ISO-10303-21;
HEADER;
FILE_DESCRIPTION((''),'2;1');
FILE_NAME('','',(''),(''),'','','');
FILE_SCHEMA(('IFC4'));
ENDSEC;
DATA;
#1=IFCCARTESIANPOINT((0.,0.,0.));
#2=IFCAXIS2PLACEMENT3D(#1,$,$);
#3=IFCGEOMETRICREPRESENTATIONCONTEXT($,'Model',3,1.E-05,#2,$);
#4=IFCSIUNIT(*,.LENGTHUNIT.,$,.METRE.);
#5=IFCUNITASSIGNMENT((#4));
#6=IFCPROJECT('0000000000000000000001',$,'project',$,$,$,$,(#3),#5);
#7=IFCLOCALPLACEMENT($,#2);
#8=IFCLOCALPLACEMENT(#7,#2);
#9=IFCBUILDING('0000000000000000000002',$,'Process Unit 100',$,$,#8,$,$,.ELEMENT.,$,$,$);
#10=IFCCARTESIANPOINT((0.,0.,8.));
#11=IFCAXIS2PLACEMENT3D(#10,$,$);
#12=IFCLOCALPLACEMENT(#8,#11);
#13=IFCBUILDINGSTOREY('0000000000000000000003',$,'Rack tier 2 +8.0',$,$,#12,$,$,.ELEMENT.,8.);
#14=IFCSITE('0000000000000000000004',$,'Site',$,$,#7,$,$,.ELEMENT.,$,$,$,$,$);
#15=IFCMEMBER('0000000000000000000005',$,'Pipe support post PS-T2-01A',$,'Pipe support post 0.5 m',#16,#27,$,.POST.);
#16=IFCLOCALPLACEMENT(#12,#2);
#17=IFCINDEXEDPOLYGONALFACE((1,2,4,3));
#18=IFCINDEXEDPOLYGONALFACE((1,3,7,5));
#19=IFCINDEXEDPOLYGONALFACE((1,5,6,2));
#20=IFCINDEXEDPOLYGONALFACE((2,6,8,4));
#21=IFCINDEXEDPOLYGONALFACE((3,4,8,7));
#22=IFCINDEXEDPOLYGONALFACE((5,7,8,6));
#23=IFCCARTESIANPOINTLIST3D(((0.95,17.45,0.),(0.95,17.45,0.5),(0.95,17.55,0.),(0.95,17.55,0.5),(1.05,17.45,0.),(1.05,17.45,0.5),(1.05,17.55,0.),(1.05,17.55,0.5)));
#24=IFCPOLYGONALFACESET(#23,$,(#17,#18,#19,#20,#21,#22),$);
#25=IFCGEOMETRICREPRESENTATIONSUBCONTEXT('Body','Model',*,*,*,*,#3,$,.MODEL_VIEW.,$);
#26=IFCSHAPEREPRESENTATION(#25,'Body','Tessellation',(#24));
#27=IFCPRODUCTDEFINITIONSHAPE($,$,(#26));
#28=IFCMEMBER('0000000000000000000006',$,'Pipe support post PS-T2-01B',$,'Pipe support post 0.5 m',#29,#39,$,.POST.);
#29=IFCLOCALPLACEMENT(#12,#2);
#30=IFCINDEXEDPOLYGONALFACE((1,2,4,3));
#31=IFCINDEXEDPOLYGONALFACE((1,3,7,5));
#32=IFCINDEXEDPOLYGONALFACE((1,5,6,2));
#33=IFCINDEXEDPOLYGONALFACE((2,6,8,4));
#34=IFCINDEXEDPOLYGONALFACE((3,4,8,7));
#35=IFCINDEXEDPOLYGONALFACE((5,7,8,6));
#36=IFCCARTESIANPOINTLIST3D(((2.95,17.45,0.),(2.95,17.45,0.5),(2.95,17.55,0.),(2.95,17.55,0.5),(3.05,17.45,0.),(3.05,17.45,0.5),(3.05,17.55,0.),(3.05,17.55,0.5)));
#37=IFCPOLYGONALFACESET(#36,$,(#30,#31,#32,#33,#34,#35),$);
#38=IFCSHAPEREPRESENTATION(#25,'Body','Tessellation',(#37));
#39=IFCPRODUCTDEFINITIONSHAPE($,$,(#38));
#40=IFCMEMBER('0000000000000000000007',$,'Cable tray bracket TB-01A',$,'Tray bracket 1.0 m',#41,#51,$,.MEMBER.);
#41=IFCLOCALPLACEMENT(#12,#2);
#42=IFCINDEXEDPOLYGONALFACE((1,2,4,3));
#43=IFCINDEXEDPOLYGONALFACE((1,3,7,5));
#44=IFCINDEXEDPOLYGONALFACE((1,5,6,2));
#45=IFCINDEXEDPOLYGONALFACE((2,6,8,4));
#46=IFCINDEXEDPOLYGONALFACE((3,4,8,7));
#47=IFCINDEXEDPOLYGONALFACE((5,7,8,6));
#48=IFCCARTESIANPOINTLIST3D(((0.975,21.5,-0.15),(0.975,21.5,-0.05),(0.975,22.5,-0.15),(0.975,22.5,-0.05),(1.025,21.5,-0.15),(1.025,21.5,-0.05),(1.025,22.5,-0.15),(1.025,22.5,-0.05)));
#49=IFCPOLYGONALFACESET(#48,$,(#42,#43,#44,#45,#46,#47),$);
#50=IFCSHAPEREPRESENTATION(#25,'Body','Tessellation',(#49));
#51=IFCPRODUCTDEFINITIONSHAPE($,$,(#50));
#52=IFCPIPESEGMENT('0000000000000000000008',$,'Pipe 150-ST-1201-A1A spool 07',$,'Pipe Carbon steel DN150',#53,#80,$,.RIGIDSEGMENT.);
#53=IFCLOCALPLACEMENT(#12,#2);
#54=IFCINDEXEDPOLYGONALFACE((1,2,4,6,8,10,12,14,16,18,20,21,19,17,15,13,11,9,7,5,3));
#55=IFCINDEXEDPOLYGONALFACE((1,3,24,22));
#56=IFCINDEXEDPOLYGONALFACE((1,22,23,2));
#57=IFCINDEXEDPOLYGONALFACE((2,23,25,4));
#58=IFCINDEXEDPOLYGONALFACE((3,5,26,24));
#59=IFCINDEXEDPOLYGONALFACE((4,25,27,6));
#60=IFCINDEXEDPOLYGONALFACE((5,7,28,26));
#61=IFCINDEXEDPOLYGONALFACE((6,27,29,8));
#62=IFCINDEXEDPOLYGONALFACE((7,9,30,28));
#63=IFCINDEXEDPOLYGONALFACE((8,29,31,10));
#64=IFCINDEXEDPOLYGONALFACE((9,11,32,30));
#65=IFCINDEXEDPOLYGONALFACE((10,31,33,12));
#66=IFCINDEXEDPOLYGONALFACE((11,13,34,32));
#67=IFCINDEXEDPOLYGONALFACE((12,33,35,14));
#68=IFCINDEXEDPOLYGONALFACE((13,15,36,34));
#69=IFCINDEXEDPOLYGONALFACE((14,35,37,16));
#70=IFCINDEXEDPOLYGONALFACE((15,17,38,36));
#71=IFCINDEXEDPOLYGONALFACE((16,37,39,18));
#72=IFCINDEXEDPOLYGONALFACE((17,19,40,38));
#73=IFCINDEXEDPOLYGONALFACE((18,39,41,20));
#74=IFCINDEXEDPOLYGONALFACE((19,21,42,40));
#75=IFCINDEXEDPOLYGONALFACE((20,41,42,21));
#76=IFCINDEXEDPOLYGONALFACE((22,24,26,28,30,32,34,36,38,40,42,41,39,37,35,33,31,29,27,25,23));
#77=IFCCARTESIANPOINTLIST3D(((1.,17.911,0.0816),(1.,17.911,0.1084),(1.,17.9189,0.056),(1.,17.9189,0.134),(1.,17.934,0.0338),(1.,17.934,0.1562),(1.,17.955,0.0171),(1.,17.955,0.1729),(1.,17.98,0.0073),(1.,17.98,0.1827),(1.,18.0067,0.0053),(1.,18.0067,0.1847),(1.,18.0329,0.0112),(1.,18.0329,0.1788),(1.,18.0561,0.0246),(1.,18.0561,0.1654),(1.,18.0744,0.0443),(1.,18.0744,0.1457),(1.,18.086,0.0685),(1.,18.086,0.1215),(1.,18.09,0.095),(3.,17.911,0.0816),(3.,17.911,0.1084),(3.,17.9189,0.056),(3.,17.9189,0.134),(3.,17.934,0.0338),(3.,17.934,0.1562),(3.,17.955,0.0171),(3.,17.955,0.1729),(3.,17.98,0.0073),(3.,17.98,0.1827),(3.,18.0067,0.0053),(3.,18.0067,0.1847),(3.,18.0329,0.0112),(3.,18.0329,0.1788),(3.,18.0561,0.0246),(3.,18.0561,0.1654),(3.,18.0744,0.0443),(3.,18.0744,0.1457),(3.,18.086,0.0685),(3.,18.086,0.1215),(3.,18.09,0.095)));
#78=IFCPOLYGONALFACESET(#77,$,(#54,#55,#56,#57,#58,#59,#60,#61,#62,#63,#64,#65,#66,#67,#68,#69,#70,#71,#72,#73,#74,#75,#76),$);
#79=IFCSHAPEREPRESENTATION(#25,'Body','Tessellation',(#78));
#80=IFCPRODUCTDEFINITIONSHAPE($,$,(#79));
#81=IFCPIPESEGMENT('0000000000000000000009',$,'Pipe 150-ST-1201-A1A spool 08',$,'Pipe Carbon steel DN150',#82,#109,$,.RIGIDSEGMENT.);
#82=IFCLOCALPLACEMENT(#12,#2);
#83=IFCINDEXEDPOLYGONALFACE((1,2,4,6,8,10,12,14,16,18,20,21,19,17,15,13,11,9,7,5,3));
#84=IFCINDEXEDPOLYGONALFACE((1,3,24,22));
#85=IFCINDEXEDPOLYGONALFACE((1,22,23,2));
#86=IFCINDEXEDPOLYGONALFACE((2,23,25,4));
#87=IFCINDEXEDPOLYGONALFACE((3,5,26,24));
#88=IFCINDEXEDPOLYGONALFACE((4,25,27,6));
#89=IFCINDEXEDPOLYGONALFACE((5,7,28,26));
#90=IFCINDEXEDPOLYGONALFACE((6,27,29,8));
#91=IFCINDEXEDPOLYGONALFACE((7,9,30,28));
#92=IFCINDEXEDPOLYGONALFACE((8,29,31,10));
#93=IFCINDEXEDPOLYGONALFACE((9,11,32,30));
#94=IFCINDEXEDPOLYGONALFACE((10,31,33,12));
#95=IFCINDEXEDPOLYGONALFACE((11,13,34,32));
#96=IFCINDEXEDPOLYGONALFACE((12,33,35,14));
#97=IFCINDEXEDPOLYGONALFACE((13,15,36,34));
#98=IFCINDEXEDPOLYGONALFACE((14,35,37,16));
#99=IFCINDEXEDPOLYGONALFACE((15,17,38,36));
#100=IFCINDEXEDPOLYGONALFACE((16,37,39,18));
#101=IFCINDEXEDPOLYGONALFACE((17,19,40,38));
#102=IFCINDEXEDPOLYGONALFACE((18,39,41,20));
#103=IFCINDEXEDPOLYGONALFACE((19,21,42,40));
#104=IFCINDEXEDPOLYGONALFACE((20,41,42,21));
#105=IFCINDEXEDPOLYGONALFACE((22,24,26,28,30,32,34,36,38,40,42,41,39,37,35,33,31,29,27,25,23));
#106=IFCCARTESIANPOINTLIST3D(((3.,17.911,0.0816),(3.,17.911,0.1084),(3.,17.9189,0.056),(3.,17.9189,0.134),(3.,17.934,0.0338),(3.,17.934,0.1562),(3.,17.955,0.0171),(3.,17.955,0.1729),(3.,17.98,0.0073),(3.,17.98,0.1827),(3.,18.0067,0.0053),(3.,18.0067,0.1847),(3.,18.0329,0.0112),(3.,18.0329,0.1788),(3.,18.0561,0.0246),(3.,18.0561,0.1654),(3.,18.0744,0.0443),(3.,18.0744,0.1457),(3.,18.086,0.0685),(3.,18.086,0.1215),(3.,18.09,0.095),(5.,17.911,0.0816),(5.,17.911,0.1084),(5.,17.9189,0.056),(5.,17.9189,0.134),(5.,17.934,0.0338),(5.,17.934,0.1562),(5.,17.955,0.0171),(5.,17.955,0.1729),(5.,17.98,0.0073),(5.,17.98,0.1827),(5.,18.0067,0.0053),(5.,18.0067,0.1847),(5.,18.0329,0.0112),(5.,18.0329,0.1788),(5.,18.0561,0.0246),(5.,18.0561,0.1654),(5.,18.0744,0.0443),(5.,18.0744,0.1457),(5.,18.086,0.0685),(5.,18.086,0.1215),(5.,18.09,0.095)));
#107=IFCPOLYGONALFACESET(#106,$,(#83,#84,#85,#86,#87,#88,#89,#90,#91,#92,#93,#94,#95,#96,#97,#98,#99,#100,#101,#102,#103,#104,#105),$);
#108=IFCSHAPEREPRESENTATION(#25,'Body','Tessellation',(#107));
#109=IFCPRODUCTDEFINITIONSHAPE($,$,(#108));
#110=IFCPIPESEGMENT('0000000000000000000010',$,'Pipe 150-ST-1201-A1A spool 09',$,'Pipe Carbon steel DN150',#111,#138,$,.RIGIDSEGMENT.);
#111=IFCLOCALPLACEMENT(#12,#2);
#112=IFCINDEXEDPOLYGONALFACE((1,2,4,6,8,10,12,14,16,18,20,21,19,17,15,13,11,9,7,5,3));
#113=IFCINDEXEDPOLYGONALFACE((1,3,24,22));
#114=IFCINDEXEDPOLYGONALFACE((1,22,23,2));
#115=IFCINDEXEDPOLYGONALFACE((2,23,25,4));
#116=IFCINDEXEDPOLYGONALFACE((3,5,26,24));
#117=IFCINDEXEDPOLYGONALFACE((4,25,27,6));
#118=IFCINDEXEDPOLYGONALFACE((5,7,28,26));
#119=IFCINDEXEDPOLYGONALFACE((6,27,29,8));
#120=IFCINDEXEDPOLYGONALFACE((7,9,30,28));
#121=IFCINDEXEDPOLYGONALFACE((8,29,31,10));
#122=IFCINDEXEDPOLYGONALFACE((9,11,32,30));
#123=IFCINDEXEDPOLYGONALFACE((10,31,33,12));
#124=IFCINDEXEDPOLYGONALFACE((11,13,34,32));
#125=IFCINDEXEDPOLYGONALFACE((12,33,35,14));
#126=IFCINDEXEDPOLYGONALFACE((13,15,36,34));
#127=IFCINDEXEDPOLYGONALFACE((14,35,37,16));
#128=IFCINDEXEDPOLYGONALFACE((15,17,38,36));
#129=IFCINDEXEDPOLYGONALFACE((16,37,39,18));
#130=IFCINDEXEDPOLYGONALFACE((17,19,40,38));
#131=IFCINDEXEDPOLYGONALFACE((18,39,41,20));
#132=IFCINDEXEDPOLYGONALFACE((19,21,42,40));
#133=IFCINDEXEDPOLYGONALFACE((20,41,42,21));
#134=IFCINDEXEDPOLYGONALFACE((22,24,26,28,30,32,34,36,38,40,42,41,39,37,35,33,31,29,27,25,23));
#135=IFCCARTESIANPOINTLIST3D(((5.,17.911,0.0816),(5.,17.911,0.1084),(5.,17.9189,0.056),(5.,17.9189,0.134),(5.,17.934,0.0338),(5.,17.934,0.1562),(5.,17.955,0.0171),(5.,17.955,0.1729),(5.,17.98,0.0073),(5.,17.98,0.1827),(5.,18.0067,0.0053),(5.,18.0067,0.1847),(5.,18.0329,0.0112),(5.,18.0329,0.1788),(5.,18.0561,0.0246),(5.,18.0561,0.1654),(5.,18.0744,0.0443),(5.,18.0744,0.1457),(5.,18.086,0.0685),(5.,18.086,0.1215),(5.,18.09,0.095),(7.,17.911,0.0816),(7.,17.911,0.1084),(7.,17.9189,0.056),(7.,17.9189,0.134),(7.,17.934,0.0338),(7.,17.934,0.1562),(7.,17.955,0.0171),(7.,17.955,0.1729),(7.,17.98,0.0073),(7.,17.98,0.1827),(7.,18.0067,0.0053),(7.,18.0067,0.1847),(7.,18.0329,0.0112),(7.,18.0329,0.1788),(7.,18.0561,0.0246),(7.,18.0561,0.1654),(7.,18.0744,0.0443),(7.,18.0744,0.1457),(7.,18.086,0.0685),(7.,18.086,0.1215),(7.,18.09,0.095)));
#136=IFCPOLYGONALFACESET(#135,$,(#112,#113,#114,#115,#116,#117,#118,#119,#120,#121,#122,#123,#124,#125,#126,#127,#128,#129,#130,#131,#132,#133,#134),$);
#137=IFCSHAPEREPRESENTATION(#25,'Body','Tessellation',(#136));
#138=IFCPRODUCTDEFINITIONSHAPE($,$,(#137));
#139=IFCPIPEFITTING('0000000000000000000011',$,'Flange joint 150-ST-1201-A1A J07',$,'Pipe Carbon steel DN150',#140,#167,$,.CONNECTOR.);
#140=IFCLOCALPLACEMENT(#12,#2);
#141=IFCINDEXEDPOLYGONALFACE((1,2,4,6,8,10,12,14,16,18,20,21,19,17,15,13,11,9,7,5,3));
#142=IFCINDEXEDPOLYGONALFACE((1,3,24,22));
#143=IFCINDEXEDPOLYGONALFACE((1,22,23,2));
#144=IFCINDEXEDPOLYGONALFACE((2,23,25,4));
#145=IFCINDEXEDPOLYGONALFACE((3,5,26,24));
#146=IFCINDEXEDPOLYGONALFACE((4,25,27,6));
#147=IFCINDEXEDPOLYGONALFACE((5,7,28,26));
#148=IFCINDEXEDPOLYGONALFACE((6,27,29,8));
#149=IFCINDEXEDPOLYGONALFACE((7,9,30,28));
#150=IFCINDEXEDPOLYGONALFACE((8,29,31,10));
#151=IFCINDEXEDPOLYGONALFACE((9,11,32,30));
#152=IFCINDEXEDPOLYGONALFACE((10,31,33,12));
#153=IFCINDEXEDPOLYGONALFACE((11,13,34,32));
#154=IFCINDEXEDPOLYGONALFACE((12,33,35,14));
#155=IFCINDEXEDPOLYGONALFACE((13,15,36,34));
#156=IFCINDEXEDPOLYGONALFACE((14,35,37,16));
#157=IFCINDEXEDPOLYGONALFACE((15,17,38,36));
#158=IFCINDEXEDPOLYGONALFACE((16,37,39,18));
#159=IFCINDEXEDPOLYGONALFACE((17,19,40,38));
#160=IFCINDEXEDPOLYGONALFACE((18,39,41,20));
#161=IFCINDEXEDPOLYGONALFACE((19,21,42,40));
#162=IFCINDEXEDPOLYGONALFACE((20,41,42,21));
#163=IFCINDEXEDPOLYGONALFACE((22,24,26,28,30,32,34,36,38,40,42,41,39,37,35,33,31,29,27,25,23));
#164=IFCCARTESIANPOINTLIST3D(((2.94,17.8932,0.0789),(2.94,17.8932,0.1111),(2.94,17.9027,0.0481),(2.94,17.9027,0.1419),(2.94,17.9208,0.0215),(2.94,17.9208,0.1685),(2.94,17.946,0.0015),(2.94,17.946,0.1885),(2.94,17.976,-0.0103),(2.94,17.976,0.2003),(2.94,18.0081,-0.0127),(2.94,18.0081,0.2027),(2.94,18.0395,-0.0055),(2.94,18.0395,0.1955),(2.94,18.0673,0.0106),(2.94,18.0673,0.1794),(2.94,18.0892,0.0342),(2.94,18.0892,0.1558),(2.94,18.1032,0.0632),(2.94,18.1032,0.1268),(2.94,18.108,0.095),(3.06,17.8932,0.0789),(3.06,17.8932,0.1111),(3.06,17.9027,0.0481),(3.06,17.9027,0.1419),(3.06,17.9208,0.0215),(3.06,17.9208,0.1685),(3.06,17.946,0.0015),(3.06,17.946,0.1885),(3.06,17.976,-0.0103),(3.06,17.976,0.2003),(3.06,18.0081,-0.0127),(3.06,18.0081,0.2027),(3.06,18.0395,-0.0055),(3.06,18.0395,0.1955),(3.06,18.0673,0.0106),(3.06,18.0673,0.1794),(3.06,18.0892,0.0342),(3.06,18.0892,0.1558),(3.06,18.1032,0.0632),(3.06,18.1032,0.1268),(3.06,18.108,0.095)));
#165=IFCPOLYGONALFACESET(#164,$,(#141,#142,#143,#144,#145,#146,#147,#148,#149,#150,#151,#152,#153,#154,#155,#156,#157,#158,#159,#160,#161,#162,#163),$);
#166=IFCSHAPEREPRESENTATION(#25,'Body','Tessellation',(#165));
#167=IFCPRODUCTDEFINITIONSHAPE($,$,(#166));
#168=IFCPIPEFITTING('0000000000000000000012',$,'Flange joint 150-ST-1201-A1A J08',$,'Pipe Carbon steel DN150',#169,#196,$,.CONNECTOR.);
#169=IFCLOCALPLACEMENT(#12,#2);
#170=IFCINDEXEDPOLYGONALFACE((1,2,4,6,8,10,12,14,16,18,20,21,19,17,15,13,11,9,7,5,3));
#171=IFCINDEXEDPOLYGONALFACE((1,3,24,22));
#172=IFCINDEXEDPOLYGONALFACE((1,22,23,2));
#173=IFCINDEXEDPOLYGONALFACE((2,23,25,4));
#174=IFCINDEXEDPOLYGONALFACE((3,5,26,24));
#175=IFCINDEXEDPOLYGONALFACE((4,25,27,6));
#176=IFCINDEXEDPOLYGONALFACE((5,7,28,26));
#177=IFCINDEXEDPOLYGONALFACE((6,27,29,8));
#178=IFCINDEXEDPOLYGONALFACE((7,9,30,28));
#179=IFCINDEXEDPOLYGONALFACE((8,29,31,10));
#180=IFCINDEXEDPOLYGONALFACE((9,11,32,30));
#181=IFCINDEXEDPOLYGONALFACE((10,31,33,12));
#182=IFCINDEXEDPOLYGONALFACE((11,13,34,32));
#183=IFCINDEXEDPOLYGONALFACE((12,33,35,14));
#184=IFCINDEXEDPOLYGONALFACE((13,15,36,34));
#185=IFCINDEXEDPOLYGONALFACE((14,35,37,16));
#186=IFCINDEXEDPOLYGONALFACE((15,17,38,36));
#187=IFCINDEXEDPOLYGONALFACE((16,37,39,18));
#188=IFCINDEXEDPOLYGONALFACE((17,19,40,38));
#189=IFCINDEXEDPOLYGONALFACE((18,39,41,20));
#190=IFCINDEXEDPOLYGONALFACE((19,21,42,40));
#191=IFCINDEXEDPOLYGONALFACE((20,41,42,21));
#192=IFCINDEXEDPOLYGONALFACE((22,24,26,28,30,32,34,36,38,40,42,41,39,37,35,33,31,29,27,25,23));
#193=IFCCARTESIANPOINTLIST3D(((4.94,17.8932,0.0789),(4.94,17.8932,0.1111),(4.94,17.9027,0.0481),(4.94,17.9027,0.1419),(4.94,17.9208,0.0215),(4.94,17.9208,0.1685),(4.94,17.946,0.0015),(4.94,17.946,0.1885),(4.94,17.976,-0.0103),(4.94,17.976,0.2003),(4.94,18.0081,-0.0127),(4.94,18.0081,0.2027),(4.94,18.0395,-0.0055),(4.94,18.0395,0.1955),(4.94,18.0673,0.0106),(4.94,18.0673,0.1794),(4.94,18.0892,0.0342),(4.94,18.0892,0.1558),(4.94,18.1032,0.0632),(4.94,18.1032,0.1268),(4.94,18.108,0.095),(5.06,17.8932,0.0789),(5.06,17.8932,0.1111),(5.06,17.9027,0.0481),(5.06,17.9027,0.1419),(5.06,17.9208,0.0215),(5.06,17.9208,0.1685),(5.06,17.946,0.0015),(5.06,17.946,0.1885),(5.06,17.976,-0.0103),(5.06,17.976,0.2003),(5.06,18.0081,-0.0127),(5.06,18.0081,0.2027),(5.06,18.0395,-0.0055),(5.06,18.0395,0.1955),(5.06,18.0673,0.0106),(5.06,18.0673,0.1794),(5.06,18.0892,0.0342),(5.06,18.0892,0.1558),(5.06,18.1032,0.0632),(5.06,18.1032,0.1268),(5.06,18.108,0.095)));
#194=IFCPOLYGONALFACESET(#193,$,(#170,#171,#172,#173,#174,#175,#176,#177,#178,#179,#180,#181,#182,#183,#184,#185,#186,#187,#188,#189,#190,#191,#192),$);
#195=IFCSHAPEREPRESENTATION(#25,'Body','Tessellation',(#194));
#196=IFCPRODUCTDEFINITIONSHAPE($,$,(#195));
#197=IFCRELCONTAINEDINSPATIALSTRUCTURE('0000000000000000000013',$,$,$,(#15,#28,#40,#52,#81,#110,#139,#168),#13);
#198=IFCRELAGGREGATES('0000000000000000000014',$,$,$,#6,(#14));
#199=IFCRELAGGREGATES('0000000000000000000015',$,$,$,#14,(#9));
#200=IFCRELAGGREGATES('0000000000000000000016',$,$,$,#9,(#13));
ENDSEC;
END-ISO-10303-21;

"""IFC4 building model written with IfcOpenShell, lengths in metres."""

from ifc_helpers import new_model, si_unit, frame, origin, place, context, subcontext, project, spatial, rectangle, circle, extrude, element, save


model = new_model("IFC4")

# Units and contexts
model_context = context("Model", 3, precision=1e-05, world=origin())
body_context = subcontext(model_context, "Body", "Model", "MODEL_VIEW")
ifc_project = project(units=[si_unit("LENGTHUNIT", "METRE")], contexts=[model_context])

# Site, building, storey
site_placement = place(None, origin())
site = spatial("IfcSite", under=ifc_project, at=site_placement, Name="Site", CompositionType="ELEMENT")
building_placement = place(site_placement, origin())
building = spatial("IfcBuilding", under=site, at=building_placement, Name="Process Unit 100", CompositionType="ELEMENT")
storey_placement = place(building_placement, frame((0.0, 0.0, 8.0)))
storey = spatial("IfcBuildingStorey", under=building, at=storey_placement, Name="Rack tier 2 +8.0", CompositionType="ELEMENT", Elevation=8.0)

# Members
for number, where, z_axis, x_axis, name in (
    (1, (1.0, 17.5, 0.0), (0.0, 0.0, 1.0), (1.0, 0.0, 0.0), "Pipe support post PS-T2-01A"),
    (2, (3.0, 17.5, 0.0), (0.0, 0.0, 1.0), (1.0, 0.0, 0.0), "Pipe support post PS-T2-01B"),
):
    element("IfcMember", number, at=place(storey_placement, frame(where, z_axis=z_axis, x_axis=x_axis)), inside=storey, Name=name, ObjectType="Pipe support post 0.5 m", PredefinedType="POST", context=body_context, shape_type="SweptSolid", body=[
        extrude(rectangle(XDim=0.1, YDim=0.1), origin(), (0.0, 0.0, 1.0), 0.5),
    ])
member_placement = place(storey_placement, frame((1.0, 21.5, -0.1), z_axis=(0.0, 1.0, 0.0), x_axis=(-1.0, 0.0, 0.0)))
element("IfcMember", 3, at=member_placement, inside=storey, Name="Cable tray bracket TB-01A", ObjectType="Tray bracket 1.0 m", PredefinedType="MEMBER", context=body_context, shape_type="SweptSolid", body=[
    extrude(rectangle(XDim=0.05, YDim=0.1), origin(), (0.0, 0.0, 1.0), 1.0),
])

# Pipe segments
for number, where, z_axis, x_axis, name in (
    (4, (1.0, 18.0, 0.095), (1.0, 0.0, 0.0), (0.0, 1.0, 0.0), "Pipe 150-ST-1201-A1A spool 07"),
    (5, (3.0, 18.0, 0.095), (1.0, 0.0, 0.0), (0.0, 1.0, 0.0), "Pipe 150-ST-1201-A1A spool 08"),
    (6, (5.0, 18.0, 0.095), (1.0, 0.0, 0.0), (0.0, 1.0, 0.0), "Pipe 150-ST-1201-A1A spool 09"),
):
    element("IfcPipeSegment", number, at=place(storey_placement, frame(where, z_axis=z_axis, x_axis=x_axis)), inside=storey, Name=name, ObjectType="Pipe Carbon steel DN150", PredefinedType="RIGIDSEGMENT", context=body_context, shape_type="SweptSolid", body=[
        extrude(circle(Radius=0.09), origin(), (0.0, 0.0, 1.0), 2.0),
    ])

# Pipe fittings
for number, where, z_axis, x_axis, name in (
    (7, (2.94, 18.0, 0.095), (1.0, 0.0, 0.0), (0.0, 1.0, 0.0), "Flange joint 150-ST-1201-A1A J07"),
    (8, (4.94, 18.0, 0.095), (1.0, 0.0, 0.0), (0.0, 1.0, 0.0), "Flange joint 150-ST-1201-A1A J08"),
):
    element("IfcPipeFitting", number, at=place(storey_placement, frame(where, z_axis=z_axis, x_axis=x_axis)), inside=storey, Name=name, ObjectType="Pipe Carbon steel DN150", PredefinedType="CONNECTOR", context=body_context, shape_type="SweptSolid", body=[
        extrude(circle(Radius=0.108), origin(), (0.0, 0.0, 1.0), 0.12),
    ])

save(model, "model.ifc")
